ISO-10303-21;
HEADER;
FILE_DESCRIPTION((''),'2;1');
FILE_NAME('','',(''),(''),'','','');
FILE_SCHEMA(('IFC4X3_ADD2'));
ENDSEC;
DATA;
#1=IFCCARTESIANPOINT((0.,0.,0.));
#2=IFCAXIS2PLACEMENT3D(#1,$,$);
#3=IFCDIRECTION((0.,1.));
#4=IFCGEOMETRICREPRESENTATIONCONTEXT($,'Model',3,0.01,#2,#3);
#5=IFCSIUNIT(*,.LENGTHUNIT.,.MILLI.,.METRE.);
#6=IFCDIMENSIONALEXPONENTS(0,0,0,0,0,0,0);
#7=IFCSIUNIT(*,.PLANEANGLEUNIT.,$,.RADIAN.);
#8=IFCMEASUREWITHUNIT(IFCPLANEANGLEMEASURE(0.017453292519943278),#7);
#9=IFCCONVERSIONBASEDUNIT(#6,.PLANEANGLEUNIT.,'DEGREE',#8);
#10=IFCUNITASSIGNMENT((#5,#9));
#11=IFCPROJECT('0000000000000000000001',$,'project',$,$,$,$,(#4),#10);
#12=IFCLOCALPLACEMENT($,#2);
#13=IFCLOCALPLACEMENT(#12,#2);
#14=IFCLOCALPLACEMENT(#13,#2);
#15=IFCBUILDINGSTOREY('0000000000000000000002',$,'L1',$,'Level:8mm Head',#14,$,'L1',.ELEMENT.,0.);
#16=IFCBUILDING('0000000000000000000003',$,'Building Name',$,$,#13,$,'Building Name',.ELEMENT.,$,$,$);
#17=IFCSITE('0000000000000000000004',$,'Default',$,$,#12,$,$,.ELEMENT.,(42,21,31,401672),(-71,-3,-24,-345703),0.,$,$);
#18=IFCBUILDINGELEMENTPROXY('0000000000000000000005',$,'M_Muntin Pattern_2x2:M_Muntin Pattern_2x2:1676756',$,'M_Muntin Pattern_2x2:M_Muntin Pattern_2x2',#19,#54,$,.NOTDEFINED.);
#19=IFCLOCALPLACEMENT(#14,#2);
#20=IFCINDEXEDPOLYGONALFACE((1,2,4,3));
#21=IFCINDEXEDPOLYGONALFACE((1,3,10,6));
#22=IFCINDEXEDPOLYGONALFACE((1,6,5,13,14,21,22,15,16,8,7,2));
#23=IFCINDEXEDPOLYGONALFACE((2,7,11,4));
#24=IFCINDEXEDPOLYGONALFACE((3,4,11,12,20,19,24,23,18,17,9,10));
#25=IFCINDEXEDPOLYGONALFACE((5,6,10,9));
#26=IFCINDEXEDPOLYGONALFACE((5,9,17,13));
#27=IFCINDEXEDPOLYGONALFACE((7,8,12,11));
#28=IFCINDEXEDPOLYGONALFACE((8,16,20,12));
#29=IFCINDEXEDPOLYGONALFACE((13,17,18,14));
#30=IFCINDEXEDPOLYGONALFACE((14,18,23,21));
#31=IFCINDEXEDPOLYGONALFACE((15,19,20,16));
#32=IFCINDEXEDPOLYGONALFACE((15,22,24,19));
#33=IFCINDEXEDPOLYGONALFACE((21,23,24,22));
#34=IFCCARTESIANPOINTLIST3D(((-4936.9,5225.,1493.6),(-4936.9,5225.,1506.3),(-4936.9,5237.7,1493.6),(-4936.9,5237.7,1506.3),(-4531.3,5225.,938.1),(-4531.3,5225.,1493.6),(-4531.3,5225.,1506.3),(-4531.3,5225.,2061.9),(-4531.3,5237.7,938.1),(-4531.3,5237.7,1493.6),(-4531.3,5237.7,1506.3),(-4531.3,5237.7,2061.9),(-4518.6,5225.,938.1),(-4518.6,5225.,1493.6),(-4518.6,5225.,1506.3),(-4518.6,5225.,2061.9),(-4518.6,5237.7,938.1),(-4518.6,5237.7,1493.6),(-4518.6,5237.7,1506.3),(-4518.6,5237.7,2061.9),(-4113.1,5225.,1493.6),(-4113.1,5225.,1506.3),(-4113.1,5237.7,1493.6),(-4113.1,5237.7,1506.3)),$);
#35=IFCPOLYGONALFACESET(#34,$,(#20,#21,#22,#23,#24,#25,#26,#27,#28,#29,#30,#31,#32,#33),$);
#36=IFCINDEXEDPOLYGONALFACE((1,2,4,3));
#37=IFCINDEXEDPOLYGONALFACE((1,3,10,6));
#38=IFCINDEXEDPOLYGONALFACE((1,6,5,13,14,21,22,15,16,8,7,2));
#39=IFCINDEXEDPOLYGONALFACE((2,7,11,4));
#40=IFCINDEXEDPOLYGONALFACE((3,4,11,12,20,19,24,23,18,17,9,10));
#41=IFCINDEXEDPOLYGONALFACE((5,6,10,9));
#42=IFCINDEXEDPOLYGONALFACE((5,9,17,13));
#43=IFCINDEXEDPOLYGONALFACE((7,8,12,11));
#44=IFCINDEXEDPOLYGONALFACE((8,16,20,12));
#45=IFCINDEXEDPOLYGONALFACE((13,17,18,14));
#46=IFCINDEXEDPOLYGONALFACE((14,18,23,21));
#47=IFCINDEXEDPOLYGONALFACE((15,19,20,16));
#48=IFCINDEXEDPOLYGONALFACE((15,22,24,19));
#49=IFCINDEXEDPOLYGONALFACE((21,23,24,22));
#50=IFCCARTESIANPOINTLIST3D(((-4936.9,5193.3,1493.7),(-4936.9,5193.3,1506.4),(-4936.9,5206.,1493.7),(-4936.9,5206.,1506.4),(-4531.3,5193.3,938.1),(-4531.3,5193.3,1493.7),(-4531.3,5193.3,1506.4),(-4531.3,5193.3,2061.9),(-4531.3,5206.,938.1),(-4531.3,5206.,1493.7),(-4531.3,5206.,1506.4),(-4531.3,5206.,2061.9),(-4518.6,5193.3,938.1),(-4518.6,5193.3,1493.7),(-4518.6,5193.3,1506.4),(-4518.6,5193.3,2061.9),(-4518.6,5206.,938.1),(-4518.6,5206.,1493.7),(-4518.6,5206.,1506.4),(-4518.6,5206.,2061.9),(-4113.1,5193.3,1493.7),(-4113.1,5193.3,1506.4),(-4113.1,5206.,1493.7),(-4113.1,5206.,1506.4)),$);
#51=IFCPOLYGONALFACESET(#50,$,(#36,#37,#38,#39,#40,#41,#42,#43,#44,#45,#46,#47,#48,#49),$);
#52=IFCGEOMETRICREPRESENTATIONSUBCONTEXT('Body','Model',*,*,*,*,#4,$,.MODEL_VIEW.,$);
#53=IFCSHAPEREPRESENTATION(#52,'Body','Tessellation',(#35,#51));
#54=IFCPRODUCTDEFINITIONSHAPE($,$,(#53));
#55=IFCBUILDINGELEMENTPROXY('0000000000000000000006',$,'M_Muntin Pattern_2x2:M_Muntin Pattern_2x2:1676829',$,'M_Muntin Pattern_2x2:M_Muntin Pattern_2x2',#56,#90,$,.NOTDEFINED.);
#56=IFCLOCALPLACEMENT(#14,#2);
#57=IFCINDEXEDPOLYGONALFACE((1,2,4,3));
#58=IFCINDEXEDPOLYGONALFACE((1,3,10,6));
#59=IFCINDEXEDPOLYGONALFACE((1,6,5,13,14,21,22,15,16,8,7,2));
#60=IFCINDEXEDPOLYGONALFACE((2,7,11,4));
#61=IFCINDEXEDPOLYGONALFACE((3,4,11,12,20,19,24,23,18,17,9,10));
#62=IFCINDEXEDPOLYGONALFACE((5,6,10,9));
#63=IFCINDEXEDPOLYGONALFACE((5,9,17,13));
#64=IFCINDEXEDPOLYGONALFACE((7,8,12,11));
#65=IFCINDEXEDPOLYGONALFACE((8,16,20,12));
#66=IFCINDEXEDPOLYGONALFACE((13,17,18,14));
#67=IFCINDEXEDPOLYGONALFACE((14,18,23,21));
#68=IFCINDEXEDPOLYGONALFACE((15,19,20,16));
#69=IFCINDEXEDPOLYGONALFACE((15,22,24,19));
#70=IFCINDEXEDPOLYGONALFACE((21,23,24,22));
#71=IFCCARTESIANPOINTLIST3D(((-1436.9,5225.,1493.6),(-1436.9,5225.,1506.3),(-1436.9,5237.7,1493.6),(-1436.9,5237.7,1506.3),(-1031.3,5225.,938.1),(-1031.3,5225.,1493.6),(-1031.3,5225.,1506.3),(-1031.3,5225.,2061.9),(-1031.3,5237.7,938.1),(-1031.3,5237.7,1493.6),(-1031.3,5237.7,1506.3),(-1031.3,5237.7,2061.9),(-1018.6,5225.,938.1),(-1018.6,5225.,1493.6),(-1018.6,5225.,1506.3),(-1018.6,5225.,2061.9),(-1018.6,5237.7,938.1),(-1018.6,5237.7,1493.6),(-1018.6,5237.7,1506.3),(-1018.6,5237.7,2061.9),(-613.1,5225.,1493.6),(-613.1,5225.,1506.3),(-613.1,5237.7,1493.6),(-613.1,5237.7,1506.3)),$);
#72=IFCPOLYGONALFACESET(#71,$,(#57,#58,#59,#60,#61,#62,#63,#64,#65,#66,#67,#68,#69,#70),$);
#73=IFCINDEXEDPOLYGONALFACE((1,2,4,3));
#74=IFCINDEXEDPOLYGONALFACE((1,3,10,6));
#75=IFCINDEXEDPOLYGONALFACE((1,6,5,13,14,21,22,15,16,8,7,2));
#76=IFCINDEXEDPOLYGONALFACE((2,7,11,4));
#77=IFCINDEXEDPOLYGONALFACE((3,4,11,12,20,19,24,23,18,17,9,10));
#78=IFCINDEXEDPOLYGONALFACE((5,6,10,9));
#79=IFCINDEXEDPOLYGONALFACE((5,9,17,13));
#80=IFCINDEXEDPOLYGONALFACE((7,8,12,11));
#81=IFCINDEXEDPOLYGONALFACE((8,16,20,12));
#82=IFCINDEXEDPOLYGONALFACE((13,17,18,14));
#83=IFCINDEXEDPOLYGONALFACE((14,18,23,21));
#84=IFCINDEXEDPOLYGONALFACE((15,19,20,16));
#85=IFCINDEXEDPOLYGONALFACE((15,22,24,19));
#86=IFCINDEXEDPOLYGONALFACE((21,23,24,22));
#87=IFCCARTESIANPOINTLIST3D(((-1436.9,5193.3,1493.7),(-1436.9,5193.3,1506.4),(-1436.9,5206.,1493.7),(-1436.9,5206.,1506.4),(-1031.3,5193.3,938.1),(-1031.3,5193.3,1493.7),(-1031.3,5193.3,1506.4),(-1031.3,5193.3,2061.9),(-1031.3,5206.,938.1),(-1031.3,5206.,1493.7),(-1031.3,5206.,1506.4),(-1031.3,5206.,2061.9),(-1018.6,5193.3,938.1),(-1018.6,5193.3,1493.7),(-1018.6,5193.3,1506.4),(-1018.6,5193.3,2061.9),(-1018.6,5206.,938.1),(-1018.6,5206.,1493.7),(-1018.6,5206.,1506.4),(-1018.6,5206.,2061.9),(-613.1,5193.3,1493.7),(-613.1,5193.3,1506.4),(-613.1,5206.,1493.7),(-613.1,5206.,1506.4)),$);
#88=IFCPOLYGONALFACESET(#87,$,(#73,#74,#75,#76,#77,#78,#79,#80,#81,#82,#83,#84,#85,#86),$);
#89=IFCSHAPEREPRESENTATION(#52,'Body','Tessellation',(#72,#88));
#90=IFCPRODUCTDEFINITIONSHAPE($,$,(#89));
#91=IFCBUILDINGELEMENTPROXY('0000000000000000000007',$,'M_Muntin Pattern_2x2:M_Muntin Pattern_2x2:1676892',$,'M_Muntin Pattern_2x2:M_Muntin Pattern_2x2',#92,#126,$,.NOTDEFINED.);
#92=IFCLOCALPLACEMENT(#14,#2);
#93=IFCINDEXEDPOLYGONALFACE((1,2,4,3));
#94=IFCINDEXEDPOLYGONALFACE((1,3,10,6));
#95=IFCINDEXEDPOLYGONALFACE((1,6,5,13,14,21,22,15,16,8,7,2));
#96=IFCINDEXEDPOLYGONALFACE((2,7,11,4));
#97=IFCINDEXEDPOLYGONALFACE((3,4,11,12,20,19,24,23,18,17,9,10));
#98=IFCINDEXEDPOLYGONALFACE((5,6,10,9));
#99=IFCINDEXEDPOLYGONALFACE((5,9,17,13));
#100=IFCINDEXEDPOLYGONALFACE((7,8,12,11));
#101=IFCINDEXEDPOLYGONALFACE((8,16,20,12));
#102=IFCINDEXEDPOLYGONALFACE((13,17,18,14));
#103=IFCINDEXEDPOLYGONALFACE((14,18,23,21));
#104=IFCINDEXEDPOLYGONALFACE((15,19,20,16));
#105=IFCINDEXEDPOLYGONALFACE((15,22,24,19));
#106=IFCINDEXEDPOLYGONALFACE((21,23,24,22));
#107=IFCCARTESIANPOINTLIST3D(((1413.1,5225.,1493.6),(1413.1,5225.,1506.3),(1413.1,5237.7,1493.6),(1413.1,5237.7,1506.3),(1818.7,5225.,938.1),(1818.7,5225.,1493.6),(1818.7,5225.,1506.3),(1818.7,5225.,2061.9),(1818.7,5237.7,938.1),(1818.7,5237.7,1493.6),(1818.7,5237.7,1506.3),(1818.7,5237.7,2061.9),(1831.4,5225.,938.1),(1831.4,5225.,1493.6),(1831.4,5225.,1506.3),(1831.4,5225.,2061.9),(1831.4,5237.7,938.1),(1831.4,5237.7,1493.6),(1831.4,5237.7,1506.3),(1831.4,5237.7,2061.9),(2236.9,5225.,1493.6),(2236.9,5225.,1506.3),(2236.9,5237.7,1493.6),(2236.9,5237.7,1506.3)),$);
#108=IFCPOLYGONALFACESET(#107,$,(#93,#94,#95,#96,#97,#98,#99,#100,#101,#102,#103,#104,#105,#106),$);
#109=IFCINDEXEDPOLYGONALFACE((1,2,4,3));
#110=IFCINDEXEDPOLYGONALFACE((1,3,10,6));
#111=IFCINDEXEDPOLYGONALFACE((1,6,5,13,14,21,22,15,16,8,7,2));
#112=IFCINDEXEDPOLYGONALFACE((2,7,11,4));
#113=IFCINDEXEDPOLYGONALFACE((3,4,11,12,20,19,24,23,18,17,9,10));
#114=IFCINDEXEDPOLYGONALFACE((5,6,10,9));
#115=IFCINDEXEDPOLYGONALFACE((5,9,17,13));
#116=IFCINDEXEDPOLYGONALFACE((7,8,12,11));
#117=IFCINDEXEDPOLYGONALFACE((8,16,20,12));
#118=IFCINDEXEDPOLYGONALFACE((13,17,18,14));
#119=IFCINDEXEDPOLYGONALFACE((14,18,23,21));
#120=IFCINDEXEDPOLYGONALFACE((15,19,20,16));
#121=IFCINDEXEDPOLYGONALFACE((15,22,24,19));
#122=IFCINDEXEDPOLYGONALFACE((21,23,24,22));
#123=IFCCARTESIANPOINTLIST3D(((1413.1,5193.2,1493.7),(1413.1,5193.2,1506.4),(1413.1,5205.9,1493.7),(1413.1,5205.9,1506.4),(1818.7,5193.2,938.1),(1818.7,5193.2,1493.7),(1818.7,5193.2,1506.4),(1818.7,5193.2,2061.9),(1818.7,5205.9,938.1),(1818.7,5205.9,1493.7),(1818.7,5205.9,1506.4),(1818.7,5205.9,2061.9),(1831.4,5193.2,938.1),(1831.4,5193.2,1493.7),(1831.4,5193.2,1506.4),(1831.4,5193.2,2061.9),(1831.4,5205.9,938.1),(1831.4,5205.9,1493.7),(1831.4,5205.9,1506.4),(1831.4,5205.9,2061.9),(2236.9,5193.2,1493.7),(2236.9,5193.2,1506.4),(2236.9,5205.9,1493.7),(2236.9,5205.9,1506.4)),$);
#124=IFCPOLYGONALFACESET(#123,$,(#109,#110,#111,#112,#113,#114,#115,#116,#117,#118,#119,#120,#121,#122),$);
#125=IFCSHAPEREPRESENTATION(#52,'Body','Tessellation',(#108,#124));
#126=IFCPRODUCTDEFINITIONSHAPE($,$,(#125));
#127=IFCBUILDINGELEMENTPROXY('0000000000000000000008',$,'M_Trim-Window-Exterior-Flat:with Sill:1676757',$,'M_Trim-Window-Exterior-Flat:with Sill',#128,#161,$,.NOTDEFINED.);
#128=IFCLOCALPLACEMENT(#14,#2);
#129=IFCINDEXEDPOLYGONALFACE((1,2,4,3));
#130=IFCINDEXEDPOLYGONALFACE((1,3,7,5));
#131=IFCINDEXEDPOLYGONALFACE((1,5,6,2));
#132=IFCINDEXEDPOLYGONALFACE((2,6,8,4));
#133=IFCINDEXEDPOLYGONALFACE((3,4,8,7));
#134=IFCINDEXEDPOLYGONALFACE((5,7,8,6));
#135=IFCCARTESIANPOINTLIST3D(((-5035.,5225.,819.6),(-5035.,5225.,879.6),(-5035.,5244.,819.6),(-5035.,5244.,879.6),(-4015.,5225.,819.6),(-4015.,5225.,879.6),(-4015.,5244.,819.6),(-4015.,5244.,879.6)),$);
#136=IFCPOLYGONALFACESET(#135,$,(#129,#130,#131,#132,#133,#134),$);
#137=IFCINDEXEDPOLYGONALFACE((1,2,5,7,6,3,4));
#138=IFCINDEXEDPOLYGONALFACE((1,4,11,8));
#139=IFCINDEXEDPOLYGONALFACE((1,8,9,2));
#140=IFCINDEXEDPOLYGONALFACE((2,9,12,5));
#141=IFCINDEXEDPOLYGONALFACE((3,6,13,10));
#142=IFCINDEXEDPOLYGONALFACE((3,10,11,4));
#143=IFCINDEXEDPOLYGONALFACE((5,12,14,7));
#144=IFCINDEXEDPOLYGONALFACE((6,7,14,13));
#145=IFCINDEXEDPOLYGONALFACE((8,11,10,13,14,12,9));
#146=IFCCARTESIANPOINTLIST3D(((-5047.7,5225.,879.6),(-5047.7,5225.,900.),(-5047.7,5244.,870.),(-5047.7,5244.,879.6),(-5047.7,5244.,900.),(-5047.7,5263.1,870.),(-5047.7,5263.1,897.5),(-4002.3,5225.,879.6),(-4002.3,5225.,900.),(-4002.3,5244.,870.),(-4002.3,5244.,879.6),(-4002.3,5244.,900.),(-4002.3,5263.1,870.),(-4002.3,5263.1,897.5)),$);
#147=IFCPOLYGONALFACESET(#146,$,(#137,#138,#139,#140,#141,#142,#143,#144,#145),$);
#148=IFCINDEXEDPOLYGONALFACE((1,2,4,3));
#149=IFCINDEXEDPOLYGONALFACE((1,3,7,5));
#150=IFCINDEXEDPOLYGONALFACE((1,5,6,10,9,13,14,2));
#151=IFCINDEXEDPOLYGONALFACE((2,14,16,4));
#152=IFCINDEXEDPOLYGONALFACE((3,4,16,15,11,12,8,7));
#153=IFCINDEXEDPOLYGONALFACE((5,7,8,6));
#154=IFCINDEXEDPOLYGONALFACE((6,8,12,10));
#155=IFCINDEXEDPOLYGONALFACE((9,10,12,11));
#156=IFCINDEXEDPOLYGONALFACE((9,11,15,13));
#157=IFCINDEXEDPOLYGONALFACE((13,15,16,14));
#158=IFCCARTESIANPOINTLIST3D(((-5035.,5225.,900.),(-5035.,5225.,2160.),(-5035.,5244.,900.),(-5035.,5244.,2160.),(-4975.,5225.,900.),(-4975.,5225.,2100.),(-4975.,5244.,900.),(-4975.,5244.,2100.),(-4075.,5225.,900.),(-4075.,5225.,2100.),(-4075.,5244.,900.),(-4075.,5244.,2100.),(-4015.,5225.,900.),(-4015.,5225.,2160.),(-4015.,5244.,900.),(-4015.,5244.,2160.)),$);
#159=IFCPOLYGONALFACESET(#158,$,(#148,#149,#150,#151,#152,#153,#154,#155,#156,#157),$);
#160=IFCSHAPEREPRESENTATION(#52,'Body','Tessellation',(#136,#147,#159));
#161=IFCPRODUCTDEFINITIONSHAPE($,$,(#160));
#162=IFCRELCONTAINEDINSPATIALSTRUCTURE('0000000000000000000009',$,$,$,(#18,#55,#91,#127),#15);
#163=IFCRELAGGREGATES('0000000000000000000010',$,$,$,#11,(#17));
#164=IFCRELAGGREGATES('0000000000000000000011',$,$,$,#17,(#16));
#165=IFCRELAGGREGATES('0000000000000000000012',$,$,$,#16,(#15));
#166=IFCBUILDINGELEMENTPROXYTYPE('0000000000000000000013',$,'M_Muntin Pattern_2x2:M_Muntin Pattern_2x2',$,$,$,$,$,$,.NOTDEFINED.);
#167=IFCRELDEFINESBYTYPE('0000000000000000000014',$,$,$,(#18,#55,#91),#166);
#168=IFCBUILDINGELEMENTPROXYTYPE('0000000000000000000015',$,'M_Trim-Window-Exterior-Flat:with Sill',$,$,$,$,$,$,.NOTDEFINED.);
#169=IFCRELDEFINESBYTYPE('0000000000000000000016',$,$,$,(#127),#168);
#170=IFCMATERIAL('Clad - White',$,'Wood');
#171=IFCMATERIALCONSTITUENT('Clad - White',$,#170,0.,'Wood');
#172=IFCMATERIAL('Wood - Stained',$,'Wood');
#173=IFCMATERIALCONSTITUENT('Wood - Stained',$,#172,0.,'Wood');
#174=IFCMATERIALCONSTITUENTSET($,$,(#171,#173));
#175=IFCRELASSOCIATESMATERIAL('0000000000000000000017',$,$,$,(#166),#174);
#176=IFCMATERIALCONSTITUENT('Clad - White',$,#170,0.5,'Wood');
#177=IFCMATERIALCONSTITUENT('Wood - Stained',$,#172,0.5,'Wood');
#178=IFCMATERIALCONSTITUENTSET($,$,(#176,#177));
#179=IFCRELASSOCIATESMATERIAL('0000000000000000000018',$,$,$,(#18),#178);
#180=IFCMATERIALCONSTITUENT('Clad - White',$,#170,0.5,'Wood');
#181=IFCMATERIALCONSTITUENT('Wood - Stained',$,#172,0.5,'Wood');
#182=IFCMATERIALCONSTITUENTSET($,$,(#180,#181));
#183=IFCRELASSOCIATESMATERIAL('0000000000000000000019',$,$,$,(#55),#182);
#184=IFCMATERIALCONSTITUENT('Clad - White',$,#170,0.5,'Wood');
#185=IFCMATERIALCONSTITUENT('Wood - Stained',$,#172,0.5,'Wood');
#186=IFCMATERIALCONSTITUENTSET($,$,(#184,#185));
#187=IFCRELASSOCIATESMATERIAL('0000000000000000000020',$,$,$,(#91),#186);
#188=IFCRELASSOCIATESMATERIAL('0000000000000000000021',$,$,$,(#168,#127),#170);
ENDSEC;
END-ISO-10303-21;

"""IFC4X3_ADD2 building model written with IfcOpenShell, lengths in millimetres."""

from ifc_helpers import new_model, entity, si_unit, converted_unit, direction, frame, frame_2d, origin, place, context, subcontext, project, spatial, polyline, rectangle, outline, extrude, source, transform, mapped, material, constituent, constituent_set, type_object, type_shapes, element, save


model = new_model("IFC4X3_ADD2")

# Units and contexts
model_context = context("Model", 3, precision=0.01, world=origin(), true_north=direction((0.0, 1.0)))
body_context = subcontext(model_context, "Body", "Model", "MODEL_VIEW")
ifc_project = project(units=[si_unit("LENGTHUNIT", "METRE", prefix="MILLI"), converted_unit("PLANEANGLEUNIT", "DEGREE", entity("IfcPlaneAngleMeasure", 0.017453292519943278), si_unit("PLANEANGLEUNIT", "RADIAN"), dimensions=[0, 0, 0, 0, 0, 0, 0])], contexts=[model_context])

# Site, building, storey
site_placement = place(None, origin())
site = spatial("IfcSite", under=ifc_project, at=site_placement, Name="Default", CompositionType="ELEMENT", RefLatitude=(42, 21, 31, 401672), RefLongitude=(-71, -3, -24, -345703), RefElevation=0.0)
building_placement = place(site_placement, origin())
building = spatial("IfcBuilding", under=site, at=building_placement, Name="Building Name", LongName="Building Name", CompositionType="ELEMENT")
storey_placement = place(building_placement, origin())
storey = spatial("IfcBuildingStorey", under=building, at=storey_placement, Name="L1", ObjectType="Level:8mm Head", LongName="L1", CompositionType="ELEMENT", Elevation=0.0)

# Building element proxies
ifc_material_1 = material(Name="Clad - White", Category="Wood")
ifc_constituent_1 = constituent(ifc_material_1, Name="Clad - White", Category="Wood", fraction=0.5)
ifc_material_2 = material(Name="Wood - Stained", Category="Wood")
ifc_constituent_2 = constituent(ifc_material_2, Name="Wood - Stained", Category="Wood", fraction=0.5)
ifc_constituent_set_1 = constituent_set(constituents=[ifc_constituent_1, ifc_constituent_2])
ifc_constituent_3 = constituent(ifc_material_1, Name="Clad - White", Category="Wood", fraction=0.0)
ifc_constituent_4 = constituent(ifc_material_2, Name="Wood - Stained", Category="Wood", fraction=0.0)
ifc_constituent_set_2 = constituent_set(constituents=[ifc_constituent_3, ifc_constituent_4])
building_element_proxy_type_1 = type_object("IfcBuildingElementProxyType", Name="M_Muntin Pattern_2x2:M_Muntin Pattern_2x2", PredefinedType="NOTDEFINED", material=ifc_constituent_set_2)
shared_shape_1 = source(origin(), body_context, "Body", "SweptSolid", [
    extrude(outline(polyline([(6.4, -6.4), (561.9, -6.4), (561.9, 6.3), (6.4, 6.3), (6.4, 411.9), (-6.3, 411.9), (-6.3, 6.3), (-561.9, 6.3), (-561.9, -6.4), (-6.3, -6.4), (-6.3, -411.9), (6.4, -411.9), (6.4, -6.4)])), frame((0.0, -22.2, 561.9), z_axis=(0.0, 1.0, 0.0), x_axis=(0.0, 0.0, 1.0)), (0.0, 0.0, 1.0), 12.7),
    extrude(outline(polyline([(6.4, -6.4), (561.9, -6.4), (561.9, 6.3), (6.4, 6.3), (6.4, 411.9), (-6.3, 411.9), (-6.3, 6.3), (-561.9, 6.3), (-561.9, -6.4), (-6.3, -6.4), (-6.3, -411.9), (6.4, -411.9), (6.4, -6.4)])), frame((0.0, 9.5, 561.9), z_axis=(0.0, 1.0, 0.0), x_axis=(0.0, 0.0, 1.0)), (0.0, 0.0, 1.0), 12.7),
])
type_shapes(building_element_proxy_type_1, [shared_shape_1])
proxy_1_placement = place(storey_placement, frame((-4525.0, 5215.5, 938.1), z_axis=(0.0, 0.0, 1.0), x_axis=(-1.0, 0.0, 0.0)))
element("IfcBuildingElementProxy", 1, at=proxy_1_placement, inside=storey, type_object=building_element_proxy_type_1, material=ifc_constituent_set_1, Name="M_Muntin Pattern_2x2:M_Muntin Pattern_2x2:1676756", ObjectType="M_Muntin Pattern_2x2:M_Muntin Pattern_2x2", PredefinedType="NOTDEFINED", context=body_context, shape_type="MappedRepresentation", body=[
    mapped(shared_shape_1, transform((0.0, 0.0, 0.0), scale=1.0)),
])
ifc_constituent_5 = constituent(ifc_material_1, Name="Clad - White", Category="Wood", fraction=0.5)
ifc_constituent_6 = constituent(ifc_material_2, Name="Wood - Stained", Category="Wood", fraction=0.5)
ifc_constituent_set_3 = constituent_set(constituents=[ifc_constituent_5, ifc_constituent_6])
proxy_2_placement = place(storey_placement, frame((-1025.0, 5215.5, 938.1), z_axis=(0.0, 0.0, 1.0), x_axis=(-1.0, 0.0, 0.0)))
element("IfcBuildingElementProxy", 2, at=proxy_2_placement, inside=storey, type_object=building_element_proxy_type_1, material=ifc_constituent_set_3, Name="M_Muntin Pattern_2x2:M_Muntin Pattern_2x2:1676829", ObjectType="M_Muntin Pattern_2x2:M_Muntin Pattern_2x2", PredefinedType="NOTDEFINED", context=body_context, shape_type="MappedRepresentation", body=[
    mapped(shared_shape_1, transform((0.0, 0.0, 0.0), scale=1.0)),
])
ifc_constituent_7 = constituent(ifc_material_1, Name="Clad - White", Category="Wood", fraction=0.5)
ifc_constituent_8 = constituent(ifc_material_2, Name="Wood - Stained", Category="Wood", fraction=0.5)
ifc_constituent_set_4 = constituent_set(constituents=[ifc_constituent_7, ifc_constituent_8])
proxy_3_placement = place(storey_placement, frame((1825.0, 5215.5, 938.1), z_axis=(0.0, 0.0, 1.0), x_axis=(-1.0, 0.0, 0.0)))
element("IfcBuildingElementProxy", 3, at=proxy_3_placement, inside=storey, type_object=building_element_proxy_type_1, material=ifc_constituent_set_4, Name="M_Muntin Pattern_2x2:M_Muntin Pattern_2x2:1676892", ObjectType="M_Muntin Pattern_2x2:M_Muntin Pattern_2x2", PredefinedType="NOTDEFINED", context=body_context, shape_type="MappedRepresentation", body=[
    mapped(shared_shape_1, transform((0.0, 0.0, 0.0), scale=1.0)),
])
building_element_proxy_type_2 = type_object("IfcBuildingElementProxyType", Name="M_Trim-Window-Exterior-Flat:with Sill", PredefinedType="NOTDEFINED", material=ifc_material_1)
shared_shape_2 = source(origin(), body_context, "Body", "SweptSolid", [
    extrude(rectangle(XDim=1020.0, YDim=60.0, at=frame_2d((0.0, 0.0), x_axis=(1.0, 0.0))), frame((0.0, -1250.4, 0.0), z_axis=(0.0, 0.0, 1.0), x_axis=(-1.0, 0.0, 0.0)), (0.0, 0.0, 1.0), 19.0),
    extrude(outline(polyline([(-19.0, -15.2), (0.0, -15.2), (0.0, -5.7), (19.0, -5.7), (19.0, 14.8), (0.0, 14.8), (-19.0, 12.3), (-19.0, -15.2)])), frame((-522.7, -1214.8, 19.0), z_axis=(1.0, 0.0, 0.0), x_axis=(0.0, 0.0, -1.0)), (0.0, 0.0, 1.0), 1045.4),
    extrude(outline(polyline([(-645.0, -510.0), (615.0, -510.0), (615.0, -450.0), (-585.0, -450.0), (-585.0, 450.0), (615.0, 450.0), (615.0, 510.0), (-645.0, 510.0), (-645.0, -510.0)])), frame((0.0, -585.0, 0.0), z_axis=(0.0, 0.0, 1.0), x_axis=(0.0, -1.0, 0.0)), (0.0, 0.0, 1.0), 19.0),
])
type_shapes(building_element_proxy_type_2, [shared_shape_2])
for number, where, z_axis, x_axis, name in (
    (4, (-4525.0, 5225.0, 2100.0), (0.0, 1.0, 0.0), (-1.0, 0.0, 0.0), "M_Trim-Window-Exterior-Flat:with Sill:1676757"),
):
    element("IfcBuildingElementProxy", number, at=place(storey_placement, frame(where, z_axis=z_axis, x_axis=x_axis)), inside=storey, type_object=building_element_proxy_type_2, material=ifc_material_1, Name=name, ObjectType="M_Trim-Window-Exterior-Flat:with Sill", PredefinedType="NOTDEFINED", context=body_context, shape_type="MappedRepresentation", body=[
        mapped(shared_shape_2, transform((0.0, 0.0, 0.0), scale=1.0)),
    ])

save(model, "model.ifc")
